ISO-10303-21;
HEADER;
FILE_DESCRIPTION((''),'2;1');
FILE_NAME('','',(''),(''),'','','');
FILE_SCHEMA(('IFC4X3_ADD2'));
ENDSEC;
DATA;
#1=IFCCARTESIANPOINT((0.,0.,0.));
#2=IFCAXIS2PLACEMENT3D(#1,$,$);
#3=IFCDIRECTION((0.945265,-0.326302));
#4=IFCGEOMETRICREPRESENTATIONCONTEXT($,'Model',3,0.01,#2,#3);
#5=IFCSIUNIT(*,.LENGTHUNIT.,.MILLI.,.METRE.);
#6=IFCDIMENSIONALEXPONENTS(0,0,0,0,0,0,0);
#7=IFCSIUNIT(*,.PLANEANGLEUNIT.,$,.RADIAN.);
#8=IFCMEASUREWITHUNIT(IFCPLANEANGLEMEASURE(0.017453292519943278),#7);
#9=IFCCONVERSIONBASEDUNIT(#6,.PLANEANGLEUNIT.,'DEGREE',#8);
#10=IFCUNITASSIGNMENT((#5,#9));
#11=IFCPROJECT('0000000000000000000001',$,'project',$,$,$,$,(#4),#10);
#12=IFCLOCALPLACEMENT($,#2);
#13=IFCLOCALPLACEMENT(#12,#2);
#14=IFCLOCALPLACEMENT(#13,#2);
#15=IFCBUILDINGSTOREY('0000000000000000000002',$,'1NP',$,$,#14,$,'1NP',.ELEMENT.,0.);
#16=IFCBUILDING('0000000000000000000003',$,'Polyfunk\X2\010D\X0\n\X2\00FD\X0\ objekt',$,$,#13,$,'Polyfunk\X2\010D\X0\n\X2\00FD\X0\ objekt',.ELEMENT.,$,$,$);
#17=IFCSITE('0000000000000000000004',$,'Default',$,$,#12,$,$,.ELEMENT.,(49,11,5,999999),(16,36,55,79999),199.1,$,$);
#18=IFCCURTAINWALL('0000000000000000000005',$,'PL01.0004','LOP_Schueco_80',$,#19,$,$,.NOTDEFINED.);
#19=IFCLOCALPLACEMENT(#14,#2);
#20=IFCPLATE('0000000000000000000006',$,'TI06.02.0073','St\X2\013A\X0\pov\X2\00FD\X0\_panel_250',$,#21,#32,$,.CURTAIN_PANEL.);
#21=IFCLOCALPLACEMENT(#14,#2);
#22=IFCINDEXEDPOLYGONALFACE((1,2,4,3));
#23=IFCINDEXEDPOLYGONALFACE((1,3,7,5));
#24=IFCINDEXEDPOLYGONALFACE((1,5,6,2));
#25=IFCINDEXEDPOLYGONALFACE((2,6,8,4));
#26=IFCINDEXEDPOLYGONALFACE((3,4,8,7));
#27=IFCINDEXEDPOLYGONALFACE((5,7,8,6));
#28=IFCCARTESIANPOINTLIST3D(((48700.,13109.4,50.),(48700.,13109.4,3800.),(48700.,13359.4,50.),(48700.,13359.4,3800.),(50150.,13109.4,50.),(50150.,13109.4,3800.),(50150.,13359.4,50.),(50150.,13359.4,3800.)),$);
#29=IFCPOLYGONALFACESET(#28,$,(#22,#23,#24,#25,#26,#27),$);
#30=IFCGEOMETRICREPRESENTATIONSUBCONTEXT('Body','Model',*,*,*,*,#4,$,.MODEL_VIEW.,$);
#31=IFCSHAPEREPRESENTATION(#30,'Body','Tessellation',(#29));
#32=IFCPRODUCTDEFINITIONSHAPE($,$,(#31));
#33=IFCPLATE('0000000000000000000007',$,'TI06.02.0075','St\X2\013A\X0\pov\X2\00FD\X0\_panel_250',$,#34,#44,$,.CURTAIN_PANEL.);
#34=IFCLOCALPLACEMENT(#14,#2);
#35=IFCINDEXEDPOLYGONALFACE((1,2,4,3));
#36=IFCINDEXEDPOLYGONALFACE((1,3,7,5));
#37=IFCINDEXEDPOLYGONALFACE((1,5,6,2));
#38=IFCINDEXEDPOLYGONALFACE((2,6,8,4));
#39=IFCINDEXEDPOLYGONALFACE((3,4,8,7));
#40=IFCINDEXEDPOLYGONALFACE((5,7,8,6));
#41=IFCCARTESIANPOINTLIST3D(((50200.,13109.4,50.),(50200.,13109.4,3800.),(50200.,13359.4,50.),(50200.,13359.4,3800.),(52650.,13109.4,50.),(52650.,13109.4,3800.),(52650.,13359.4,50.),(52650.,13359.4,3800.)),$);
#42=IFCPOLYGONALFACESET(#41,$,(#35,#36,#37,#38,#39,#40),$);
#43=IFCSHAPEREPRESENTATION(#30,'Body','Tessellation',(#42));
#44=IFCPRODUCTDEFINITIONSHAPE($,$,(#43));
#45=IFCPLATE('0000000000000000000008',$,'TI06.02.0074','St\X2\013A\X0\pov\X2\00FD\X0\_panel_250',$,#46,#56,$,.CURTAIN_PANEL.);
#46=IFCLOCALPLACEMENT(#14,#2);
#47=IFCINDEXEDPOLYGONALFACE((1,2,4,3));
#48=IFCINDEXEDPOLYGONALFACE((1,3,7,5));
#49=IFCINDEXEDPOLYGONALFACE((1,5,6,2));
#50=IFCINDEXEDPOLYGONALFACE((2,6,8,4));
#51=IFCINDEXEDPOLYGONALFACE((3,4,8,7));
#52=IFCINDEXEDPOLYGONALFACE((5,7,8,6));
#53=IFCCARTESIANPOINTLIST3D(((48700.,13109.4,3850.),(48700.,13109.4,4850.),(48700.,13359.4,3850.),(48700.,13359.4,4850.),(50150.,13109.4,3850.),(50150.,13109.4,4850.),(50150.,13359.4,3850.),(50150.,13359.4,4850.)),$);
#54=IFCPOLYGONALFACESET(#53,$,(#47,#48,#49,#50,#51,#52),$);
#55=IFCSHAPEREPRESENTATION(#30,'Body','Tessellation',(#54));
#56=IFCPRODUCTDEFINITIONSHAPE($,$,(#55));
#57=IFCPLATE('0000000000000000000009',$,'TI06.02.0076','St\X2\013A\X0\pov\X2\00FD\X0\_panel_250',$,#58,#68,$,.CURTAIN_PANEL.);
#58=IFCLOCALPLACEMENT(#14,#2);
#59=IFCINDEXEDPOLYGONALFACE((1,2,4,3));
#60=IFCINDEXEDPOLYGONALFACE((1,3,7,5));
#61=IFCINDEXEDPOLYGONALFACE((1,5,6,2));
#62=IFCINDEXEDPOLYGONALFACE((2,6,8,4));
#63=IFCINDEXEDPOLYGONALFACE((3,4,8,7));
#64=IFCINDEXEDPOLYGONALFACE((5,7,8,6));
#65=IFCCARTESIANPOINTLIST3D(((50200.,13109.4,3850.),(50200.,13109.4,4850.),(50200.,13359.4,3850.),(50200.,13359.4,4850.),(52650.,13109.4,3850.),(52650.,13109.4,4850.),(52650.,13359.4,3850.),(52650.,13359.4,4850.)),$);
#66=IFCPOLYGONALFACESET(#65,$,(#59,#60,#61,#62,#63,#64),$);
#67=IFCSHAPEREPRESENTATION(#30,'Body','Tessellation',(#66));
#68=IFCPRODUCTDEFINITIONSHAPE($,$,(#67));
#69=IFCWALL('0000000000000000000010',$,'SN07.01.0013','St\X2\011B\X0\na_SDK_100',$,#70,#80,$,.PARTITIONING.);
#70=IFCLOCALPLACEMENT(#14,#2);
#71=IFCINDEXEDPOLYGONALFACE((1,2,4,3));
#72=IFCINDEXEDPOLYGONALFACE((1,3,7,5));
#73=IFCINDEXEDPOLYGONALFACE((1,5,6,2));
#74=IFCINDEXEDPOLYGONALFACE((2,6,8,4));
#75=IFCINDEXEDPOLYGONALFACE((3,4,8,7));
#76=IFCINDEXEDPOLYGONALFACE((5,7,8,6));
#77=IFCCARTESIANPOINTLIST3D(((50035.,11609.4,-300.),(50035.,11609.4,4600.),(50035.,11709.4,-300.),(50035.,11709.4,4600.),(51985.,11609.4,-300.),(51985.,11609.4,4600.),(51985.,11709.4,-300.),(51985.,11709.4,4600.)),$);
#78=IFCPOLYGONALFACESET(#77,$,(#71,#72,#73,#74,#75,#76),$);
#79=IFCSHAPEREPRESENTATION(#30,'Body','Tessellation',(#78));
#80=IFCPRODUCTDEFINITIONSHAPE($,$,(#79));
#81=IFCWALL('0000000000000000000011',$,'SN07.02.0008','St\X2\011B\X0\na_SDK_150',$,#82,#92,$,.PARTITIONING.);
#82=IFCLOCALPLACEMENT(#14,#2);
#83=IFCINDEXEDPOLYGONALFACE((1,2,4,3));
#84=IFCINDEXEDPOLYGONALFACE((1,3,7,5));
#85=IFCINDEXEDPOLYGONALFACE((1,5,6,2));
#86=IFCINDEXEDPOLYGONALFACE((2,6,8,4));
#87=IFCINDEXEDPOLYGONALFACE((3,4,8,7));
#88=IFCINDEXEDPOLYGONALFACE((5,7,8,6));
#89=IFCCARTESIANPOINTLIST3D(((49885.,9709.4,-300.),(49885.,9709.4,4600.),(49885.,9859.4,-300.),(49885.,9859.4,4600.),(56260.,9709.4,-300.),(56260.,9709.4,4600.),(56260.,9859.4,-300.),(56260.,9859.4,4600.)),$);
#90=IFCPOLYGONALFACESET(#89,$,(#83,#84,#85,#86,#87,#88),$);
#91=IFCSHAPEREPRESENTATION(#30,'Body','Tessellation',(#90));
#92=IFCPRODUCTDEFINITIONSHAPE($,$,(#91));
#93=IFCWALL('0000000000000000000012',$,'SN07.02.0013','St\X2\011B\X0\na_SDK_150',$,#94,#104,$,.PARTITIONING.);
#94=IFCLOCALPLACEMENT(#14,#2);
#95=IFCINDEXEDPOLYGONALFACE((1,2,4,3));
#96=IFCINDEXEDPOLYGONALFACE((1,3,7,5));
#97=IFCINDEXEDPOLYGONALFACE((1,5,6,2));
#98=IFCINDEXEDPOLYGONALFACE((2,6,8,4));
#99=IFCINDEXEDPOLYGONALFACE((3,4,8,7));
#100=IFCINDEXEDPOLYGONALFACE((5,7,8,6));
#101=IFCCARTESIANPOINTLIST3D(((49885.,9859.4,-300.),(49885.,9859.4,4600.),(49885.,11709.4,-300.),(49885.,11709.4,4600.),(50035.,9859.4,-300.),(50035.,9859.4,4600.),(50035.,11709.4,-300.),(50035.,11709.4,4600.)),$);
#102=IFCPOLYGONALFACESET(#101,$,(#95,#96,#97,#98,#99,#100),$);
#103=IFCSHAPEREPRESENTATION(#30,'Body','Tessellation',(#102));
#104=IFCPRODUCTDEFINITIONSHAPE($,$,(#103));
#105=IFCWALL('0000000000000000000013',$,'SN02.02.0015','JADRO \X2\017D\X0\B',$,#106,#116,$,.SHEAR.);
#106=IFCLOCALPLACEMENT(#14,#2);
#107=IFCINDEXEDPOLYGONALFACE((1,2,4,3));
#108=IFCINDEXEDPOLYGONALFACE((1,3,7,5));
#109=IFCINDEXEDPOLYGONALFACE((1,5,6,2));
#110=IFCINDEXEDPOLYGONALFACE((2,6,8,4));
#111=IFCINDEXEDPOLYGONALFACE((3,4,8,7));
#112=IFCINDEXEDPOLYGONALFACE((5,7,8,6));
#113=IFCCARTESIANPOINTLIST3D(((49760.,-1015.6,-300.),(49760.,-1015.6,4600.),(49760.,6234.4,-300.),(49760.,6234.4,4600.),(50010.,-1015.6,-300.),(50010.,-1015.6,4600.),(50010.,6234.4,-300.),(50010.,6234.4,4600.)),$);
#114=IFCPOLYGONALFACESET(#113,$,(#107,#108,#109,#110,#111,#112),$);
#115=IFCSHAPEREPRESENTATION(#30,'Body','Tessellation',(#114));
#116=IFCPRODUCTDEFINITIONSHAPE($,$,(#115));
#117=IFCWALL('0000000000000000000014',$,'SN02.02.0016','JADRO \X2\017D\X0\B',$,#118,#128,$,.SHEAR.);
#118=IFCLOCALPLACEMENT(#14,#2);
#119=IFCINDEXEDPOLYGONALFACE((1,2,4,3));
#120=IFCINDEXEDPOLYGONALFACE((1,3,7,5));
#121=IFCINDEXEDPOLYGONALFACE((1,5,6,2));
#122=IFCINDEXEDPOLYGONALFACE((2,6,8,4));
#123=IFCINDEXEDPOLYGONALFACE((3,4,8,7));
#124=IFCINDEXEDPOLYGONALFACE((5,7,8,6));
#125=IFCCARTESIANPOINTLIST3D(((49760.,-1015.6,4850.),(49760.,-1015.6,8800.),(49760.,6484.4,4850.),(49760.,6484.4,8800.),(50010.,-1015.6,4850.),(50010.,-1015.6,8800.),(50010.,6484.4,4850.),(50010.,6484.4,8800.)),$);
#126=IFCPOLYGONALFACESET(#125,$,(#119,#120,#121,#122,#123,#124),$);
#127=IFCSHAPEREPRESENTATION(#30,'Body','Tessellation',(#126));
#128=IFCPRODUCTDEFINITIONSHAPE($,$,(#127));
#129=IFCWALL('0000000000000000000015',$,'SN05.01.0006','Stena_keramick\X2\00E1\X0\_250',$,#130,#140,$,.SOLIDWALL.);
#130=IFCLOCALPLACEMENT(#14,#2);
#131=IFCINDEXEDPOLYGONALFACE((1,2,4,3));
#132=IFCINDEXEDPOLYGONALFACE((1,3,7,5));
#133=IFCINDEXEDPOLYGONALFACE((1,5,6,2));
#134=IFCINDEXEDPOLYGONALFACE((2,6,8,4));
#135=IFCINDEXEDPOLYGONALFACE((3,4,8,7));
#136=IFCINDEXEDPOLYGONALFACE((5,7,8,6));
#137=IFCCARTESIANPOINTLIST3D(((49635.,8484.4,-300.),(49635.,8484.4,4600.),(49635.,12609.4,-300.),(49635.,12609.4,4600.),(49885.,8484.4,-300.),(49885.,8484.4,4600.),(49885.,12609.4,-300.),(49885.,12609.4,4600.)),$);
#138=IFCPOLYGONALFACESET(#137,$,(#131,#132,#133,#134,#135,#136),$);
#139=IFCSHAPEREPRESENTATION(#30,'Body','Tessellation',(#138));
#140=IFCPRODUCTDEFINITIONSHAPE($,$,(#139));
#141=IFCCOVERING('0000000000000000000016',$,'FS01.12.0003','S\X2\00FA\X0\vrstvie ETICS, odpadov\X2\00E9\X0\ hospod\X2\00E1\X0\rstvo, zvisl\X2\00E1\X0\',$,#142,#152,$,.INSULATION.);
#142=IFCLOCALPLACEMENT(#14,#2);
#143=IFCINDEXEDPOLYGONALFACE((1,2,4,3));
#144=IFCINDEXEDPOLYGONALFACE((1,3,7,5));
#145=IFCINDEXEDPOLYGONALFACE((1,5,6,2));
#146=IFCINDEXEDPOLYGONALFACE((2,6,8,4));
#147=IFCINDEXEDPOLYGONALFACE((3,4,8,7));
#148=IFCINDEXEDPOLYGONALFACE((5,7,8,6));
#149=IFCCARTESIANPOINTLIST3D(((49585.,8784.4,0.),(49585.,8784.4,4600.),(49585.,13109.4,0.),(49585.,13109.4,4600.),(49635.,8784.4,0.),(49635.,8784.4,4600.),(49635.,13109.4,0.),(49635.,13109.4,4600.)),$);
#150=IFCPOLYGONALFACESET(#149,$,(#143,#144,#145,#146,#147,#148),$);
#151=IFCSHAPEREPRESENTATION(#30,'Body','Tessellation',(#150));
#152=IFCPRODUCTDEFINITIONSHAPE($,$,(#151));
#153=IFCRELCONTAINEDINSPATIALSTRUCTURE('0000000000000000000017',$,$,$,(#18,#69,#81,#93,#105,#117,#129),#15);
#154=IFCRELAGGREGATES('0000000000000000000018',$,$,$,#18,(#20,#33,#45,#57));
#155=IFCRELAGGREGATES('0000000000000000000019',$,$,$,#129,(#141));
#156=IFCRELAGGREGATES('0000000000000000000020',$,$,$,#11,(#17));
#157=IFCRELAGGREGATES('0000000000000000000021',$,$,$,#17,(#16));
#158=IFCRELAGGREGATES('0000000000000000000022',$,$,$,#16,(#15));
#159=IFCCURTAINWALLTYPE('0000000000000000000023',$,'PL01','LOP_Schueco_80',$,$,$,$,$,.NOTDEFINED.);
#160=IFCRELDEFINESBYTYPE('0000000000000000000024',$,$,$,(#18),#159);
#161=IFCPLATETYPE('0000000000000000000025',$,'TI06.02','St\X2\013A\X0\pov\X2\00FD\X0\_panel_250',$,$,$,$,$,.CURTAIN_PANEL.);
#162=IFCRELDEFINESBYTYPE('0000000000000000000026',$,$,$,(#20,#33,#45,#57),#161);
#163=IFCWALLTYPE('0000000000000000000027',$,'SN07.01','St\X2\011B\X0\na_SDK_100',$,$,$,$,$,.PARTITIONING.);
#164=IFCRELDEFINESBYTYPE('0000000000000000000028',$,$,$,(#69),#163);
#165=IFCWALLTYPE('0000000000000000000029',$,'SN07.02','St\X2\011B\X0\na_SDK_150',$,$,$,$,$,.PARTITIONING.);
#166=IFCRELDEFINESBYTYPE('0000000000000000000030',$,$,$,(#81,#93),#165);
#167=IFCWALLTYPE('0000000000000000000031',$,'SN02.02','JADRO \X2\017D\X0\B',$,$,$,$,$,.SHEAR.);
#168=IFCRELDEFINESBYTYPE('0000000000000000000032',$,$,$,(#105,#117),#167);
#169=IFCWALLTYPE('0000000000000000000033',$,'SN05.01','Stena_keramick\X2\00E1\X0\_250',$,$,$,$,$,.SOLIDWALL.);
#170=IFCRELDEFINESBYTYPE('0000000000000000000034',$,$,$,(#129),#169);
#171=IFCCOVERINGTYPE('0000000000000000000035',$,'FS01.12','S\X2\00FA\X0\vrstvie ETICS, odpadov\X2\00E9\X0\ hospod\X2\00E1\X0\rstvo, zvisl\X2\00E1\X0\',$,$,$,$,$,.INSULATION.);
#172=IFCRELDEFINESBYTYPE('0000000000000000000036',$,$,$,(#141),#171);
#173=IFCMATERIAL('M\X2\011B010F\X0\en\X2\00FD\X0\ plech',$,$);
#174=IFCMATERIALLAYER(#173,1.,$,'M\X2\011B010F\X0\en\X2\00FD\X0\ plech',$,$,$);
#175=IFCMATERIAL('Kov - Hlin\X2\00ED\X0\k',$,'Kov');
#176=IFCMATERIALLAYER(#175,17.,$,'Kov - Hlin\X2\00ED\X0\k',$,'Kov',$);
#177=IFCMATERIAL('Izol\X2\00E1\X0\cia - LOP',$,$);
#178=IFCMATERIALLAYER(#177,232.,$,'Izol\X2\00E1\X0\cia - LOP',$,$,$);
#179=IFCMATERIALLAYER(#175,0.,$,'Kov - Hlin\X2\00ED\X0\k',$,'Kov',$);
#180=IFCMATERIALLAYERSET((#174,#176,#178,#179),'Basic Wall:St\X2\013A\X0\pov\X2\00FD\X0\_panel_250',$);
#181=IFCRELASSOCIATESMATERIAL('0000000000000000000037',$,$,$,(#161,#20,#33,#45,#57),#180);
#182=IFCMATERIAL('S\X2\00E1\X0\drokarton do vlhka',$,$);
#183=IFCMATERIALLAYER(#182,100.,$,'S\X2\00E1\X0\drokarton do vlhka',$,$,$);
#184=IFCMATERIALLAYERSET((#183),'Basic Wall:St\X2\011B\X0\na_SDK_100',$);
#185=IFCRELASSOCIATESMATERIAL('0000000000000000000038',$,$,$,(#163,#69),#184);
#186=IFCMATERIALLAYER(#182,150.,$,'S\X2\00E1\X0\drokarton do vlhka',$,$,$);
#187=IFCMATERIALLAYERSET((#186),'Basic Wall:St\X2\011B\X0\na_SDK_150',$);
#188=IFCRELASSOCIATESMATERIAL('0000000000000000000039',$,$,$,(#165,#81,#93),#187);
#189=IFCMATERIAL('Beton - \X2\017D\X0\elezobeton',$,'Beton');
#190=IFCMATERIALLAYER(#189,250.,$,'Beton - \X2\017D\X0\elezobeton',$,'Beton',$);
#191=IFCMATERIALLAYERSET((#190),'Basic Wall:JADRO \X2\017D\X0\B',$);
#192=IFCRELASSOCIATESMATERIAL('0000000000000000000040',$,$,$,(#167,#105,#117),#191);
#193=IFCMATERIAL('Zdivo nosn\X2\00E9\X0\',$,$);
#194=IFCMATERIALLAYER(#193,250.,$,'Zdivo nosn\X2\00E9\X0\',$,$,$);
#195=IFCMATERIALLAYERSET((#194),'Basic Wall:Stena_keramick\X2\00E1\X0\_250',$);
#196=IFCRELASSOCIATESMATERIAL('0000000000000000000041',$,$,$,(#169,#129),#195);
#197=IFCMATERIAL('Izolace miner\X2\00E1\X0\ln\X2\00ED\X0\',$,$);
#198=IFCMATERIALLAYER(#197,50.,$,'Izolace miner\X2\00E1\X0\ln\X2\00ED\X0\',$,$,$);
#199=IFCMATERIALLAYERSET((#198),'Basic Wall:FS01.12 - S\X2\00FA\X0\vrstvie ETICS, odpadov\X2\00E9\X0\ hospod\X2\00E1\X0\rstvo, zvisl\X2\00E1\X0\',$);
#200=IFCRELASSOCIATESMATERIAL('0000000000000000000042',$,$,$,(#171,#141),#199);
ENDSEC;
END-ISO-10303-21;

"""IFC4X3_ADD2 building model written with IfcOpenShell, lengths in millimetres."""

from ifc_helpers import new_model, entity, si_unit, converted_unit, direction, frame, frame_2d, origin, origin_2d_with_axis, place, context, subcontext, project, spatial, polyline, rectangle, extrude, clip, bounded_halfspace, material, layer, layer_set, layer_usage, type_object, element, aggregate, save


model = new_model("IFC4X3_ADD2")

# Units and contexts
model_context = context("Model", 3, precision=0.01, world=origin(), true_north=direction((0.945265, -0.326302)))
body_context = subcontext(model_context, "Body", "Model", "MODEL_VIEW")
ifc_project = project(units=[si_unit("LENGTHUNIT", "METRE", prefix="MILLI"), converted_unit("PLANEANGLEUNIT", "DEGREE", entity("IfcPlaneAngleMeasure", 0.017453292519943278), si_unit("PLANEANGLEUNIT", "RADIAN"), dimensions=[0, 0, 0, 0, 0, 0, 0])], contexts=[model_context])

# Site, building, storey
site_placement = place(None, origin())
site = spatial("IfcSite", under=ifc_project, at=site_placement, Name="Default", CompositionType="ELEMENT", RefLatitude=(49, 11, 5, 999999), RefLongitude=(16, 36, 55, 79999), RefElevation=199.1)
building_placement = place(site_placement, origin())
building = spatial("IfcBuilding", under=site, at=building_placement, Name="Polyfunkčný objekt", LongName="Polyfunkčný objekt", CompositionType="ELEMENT")
storey_placement = place(building_placement, origin())
storey = spatial("IfcBuildingStorey", under=building, at=storey_placement, Name="1NP", LongName="1NP", CompositionType="ELEMENT", Elevation=0.0)

# Curtain wall, plates
curtain_wall_type = type_object("IfcCurtainWallType", Name="PL01", Description="LOP_Schueco_80", PredefinedType="NOTDEFINED")
curtain_wall_placement = place(storey_placement, origin())
curtain_wall = element("IfcCurtainWall", 1, at=curtain_wall_placement, inside=storey, type_object=curtain_wall_type, Name="PL01.0004", Description="LOP_Schueco_80", PredefinedType="NOTDEFINED")
ifc_material_1 = material(Name="Měďený plech")
ifc_layer_1 = layer(ifc_material_1, 1.0, Name="Měďený plech")
ifc_material_2 = material(Name="Kov - Hliník", Category="Kov")
ifc_layer_2 = layer(ifc_material_2, 17.0, Name="Kov - Hliník", Category="Kov")
ifc_material_3 = material(Name="Izolácia - LOP")
ifc_layer_3 = layer(ifc_material_3, 232.0, Name="Izolácia - LOP")
ifc_layer_4 = layer(ifc_material_2, 0.0, Name="Kov - Hliník", Category="Kov")
ifc_layer_set_1 = layer_set([ifc_layer_1, ifc_layer_2, ifc_layer_3, ifc_layer_4], Name="Basic Wall:Stĺpový_panel_250")
ifc_layer_usage_1 = layer_usage(ifc_layer_set_1, "AXIS2", "NEGATIVE", 125.0)
plate_type = type_object("IfcPlateType", Name="TI06.02", Description="Stĺpový_panel_250", PredefinedType="CURTAIN_PANEL", material=ifc_layer_set_1)
plate_1_placement = place(storey_placement, frame((48700.0, 13234.4, 50.0)))
plate_1 = element("IfcPlate", 2, at=plate_1_placement, type_object=plate_type, material=ifc_layer_usage_1, Name="TI06.02.0073", Description="Stĺpový_panel_250", PredefinedType="CURTAIN_PANEL", context=body_context, shape_type="SweptSolid", body=[
    extrude(rectangle(XDim=250.0, YDim=1450.0, at=frame_2d((0.0, 0.0), x_axis=(1.0, 0.0))), frame((725.0, 0.0, 0.0), z_axis=(0.0, 0.0, 1.0), x_axis=(0.0, 1.0, 0.0)), (0.0, 0.0, 1.0), 3750.0),
])
ifc_layer_usage_2 = layer_usage(ifc_layer_set_1, "AXIS2", "NEGATIVE", 125.0)
plate_2_placement = place(storey_placement, frame((50200.0, 13234.4, 50.0)))
plate_2 = element("IfcPlate", 3, at=plate_2_placement, type_object=plate_type, material=ifc_layer_usage_2, Name="TI06.02.0075", Description="Stĺpový_panel_250", PredefinedType="CURTAIN_PANEL", context=body_context, shape_type="SweptSolid", body=[
    extrude(rectangle(XDim=250.0, YDim=2450.0, at=origin_2d_with_axis()), frame((1225.0, 0.0, 0.0), z_axis=(0.0, 0.0, 1.0), x_axis=(0.0, 1.0, 0.0)), (0.0, 0.0, 1.0), 3750.0),
])
ifc_layer_usage_3 = layer_usage(ifc_layer_set_1, "AXIS2", "NEGATIVE", 125.0)
plate_3_placement = place(storey_placement, frame((48700.0, 13234.4, 3850.0)))
plate_3 = element("IfcPlate", 4, at=plate_3_placement, type_object=plate_type, material=ifc_layer_usage_3, Name="TI06.02.0074", Description="Stĺpový_panel_250", PredefinedType="CURTAIN_PANEL", context=body_context, shape_type="SweptSolid", body=[
    extrude(rectangle(XDim=250.0, YDim=1450.0, at=frame_2d((0.0, 0.0), x_axis=(1.0, 0.0))), frame((725.0, 0.0, 0.0), z_axis=(0.0, 0.0, 1.0), x_axis=(0.0, 1.0, 0.0)), (0.0, 0.0, 1.0), 1000.0),
])
ifc_layer_usage_4 = layer_usage(ifc_layer_set_1, "AXIS2", "NEGATIVE", 125.0)
plate_4_placement = place(storey_placement, frame((50200.0, 13234.4, 3850.0)))
plate_4 = element("IfcPlate", 5, at=plate_4_placement, type_object=plate_type, material=ifc_layer_usage_4, Name="TI06.02.0076", Description="Stĺpový_panel_250", PredefinedType="CURTAIN_PANEL", context=body_context, shape_type="SweptSolid", body=[
    extrude(rectangle(XDim=250.0, YDim=2450.0, at=origin_2d_with_axis()), frame((1225.0, 0.0, 0.0), z_axis=(0.0, 0.0, 1.0), x_axis=(0.0, 1.0, 0.0)), (0.0, 0.0, 1.0), 1000.0),
])
aggregate(curtain_wall, [plate_1, plate_2, plate_3, plate_4])

# Walls
ifc_material_4 = material(Name="Sádrokarton do vlhka")
ifc_layer_5 = layer(ifc_material_4, 100.0, Name="Sádrokarton do vlhka")
ifc_layer_set_2 = layer_set([ifc_layer_5], Name="Basic Wall:Stěna_SDK_100")
wall_type_1 = type_object("IfcWallType", Name="SN07.01", Description="Stěna_SDK_100", PredefinedType="PARTITIONING", material=ifc_layer_set_2)
wall_1_placement = place(storey_placement, frame((51985.0, 11659.4, -300.0), z_axis=(0.0, 0.0, 1.0), x_axis=(-1.0, 0.0, 0.0)))
element("IfcWall", 6, at=wall_1_placement, inside=storey, type_object=wall_type_1, material=ifc_layer_set_2, Name="SN07.01.0013", Description="Stěna_SDK_100", PredefinedType="PARTITIONING", context=body_context, shape_type="Clipping", body=[
    clip(clip(extrude(rectangle(XDim=1950.0, YDim=100.0, at=frame_2d((975.0, 0.0), x_axis=(-1.0, 0.0))), origin(), (0.0, 0.0, 1.0), 4900.0), bounded_halfspace(frame((0.0, -50.0, 4900.0), z_axis=(0.0, 0.0, -1.0), x_axis=(-1.0, 0.0, 0.0)), True, frame((0.0, -50.0, 4900.0)), polyline([(0.0, 0.0), (1950.0, 0.0), (1950.0, 100.0), (1050.0, 100.0), (900.0, 100.0), (0.0, 100.0), (0.0, 0.0)]))), bounded_halfspace(frame((1950.0, -50.0, 0.0), z_axis=(0.0, 0.0, 1.0), x_axis=(0.0, -1.0, 0.0)), True, frame((1950.0, -50.0, 0.0)), polyline([(0.0, 0.0), (0.0, 100.0), (-900.0, 100.0), (-1050.0, 100.0), (-1950.0, 100.0), (-1950.0, 0.0), (0.0, 0.0)]))),
])
ifc_layer_6 = layer(ifc_material_4, 150.0, Name="Sádrokarton do vlhka")
ifc_layer_set_3 = layer_set([ifc_layer_6], Name="Basic Wall:Stěna_SDK_150")
wall_type_2 = type_object("IfcWallType", Name="SN07.02", Description="Stěna_SDK_150", PredefinedType="PARTITIONING", material=ifc_layer_set_3)
wall_2_placement = place(storey_placement, frame((49885.0, 9784.4, -300.0)))
element("IfcWall", 7, at=wall_2_placement, inside=storey, type_object=wall_type_2, material=ifc_layer_set_3, Name="SN07.02.0008", Description="Stěna_SDK_150", PredefinedType="PARTITIONING", context=body_context, shape_type="Clipping", body=[
    clip(clip(extrude(rectangle(XDim=6375.0, YDim=150.0, at=frame_2d((3187.5, 0.0), x_axis=(-1.0, 0.0))), origin(), (0.0, 0.0, 1.0), 4900.0), bounded_halfspace(frame((0.0, -75.0, 4900.0), z_axis=(0.0, 0.0, -1.0), x_axis=(1.0, 0.0, 0.0)), True, frame((0.0, -75.0, 4900.0)), polyline([(0.0, 0.0), (6375.0, 0.0), (6375.0, 150.0), (2250.0, 150.0), (2100.0, 150.0), (1200.0, 150.0), (1050.0, 150.0), (150.0, 150.0), (0.0, 150.0), (0.0, 0.0)]))), bounded_halfspace(frame((6375.0, -75.0, 0.0), z_axis=(0.0, 0.0, 1.0), x_axis=(0.0, 1.0, 0.0)), True, frame((6375.0, -75.0, 0.0)), polyline([(0.0, 0.0), (0.0, 150.0), (-4125.0, 150.0), (-4275.0, 150.0), (-5175.0, 150.0), (-5325.0, 150.0), (-6225.0, 150.0), (-6375.0, 150.0), (-6375.0, 0.0), (0.0, 0.0)]))),
])
wall_3_placement = place(storey_placement, frame((49960.0, 9859.4, -300.0), z_axis=(0.0, 0.0, 1.0), x_axis=(0.0, 1.0, 0.0)))
element("IfcWall", 8, at=wall_3_placement, inside=storey, type_object=wall_type_2, material=ifc_layer_set_3, Name="SN07.02.0013", Description="Stěna_SDK_150", PredefinedType="PARTITIONING", context=body_context, shape_type="Clipping", body=[
    clip(clip(extrude(rectangle(XDim=1850.0, YDim=150.0, at=frame_2d((925.0, 0.0), x_axis=(-1.0, 0.0))), origin(), (0.0, 0.0, 1.0), 4900.0), bounded_halfspace(frame((0.0, -75.0, 4900.0), z_axis=(0.0, 0.0, -1.0), x_axis=(0.0, -1.0, 0.0)), True, frame((0.0, -75.0, 4900.0)), polyline([(0.0, 0.0), (1750.0, 0.0), (1850.0, 0.0), (1850.0, 150.0), (0.0, 150.0), (0.0, 0.0)]))), bounded_halfspace(frame((1850.0, -75.0, 0.0)), True, frame((1850.0, -75.0, 0.0)), polyline([(0.0, 0.0), (0.0, 150.0), (-1850.0, 150.0), (-1850.0, 0.0), (-100.0, 0.0), (0.0, 0.0)]))),
])
ifc_material_5 = material(Name="Beton - Železobeton", Category="Beton")
ifc_layer_7 = layer(ifc_material_5, 250.0, Name="Beton - Železobeton", Category="Beton")
ifc_layer_set_4 = layer_set([ifc_layer_7], Name="Basic Wall:JADRO ŽB")
wall_type_3 = type_object("IfcWallType", Name="SN02.02", Description="JADRO ŽB", PredefinedType="SHEAR", material=ifc_layer_set_4)
wall_4_placement = place(storey_placement, frame((49885.0, 6234.4, -300.0), z_axis=(0.0, 0.0, 1.0), x_axis=(0.0, -1.0, 0.0)))
element("IfcWall", 9, at=wall_4_placement, inside=storey, type_object=wall_type_3, material=ifc_layer_set_4, Name="SN02.02.0015", Description="JADRO ŽB", PredefinedType="SHEAR", context=body_context, shape_type="Clipping", body=[
    clip(clip(extrude(rectangle(XDim=7250.0, YDim=250.0, at=frame_2d((3625.0, 0.0), x_axis=(-1.0, 0.0))), origin(), (0.0, 0.0, 1.0), 4900.0), bounded_halfspace(frame((0.0, -125.0, 4900.0), z_axis=(0.0, 0.0, -1.0), x_axis=(0.0, 1.0, 0.0)), True, frame((0.0, -125.0, 4900.0)), polyline([(0.0, 0.0), (800.0, 0.0), (950.0, 0.0), (7250.0, 0.0), (7250.0, 250.0), (0.0, 250.0), (0.0, 0.0)]))), bounded_halfspace(frame((7250.0, -125.0, 0.0), z_axis=(0.0, 0.0, 1.0), x_axis=(-1.0, 0.0, 0.0)), True, frame((7250.0, -125.0, 0.0)), polyline([(0.0, 0.0), (0.0, 250.0), (-7250.0, 250.0), (-7250.0, 0.0), (-6450.0, 0.0), (-6300.0, 0.0), (0.0, 0.0)]))),
])
wall_5_placement = place(storey_placement, frame((49885.0, 6484.4, 4850.0), z_axis=(0.0, 0.0, 1.0), x_axis=(0.0, -1.0, 0.0)))
element("IfcWall", 10, at=wall_5_placement, inside=storey, type_object=wall_type_3, material=ifc_layer_set_4, Name="SN02.02.0016", Description="JADRO ŽB", PredefinedType="SHEAR", context=body_context, shape_type="Clipping", body=[
    clip(clip(extrude(rectangle(XDim=7500.0, YDim=250.0, at=frame_2d((3750.0, 0.0), x_axis=(-1.0, 0.0))), origin(), (0.0, 0.0, 1.0), 3950.0), bounded_halfspace(frame((7500.0, -125.0, 0.0), z_axis=(0.0, 0.0, 1.0), x_axis=(0.0, -1.0, 0.0)), True, frame((7500.0, -125.0, 0.0)), polyline([(0.0, 0.0), (0.0, 250.0), (-7500.0, 250.0), (-7500.0, 0.0), (-7250.0, 0.0), (-6450.0, 0.0), (-6300.0, 0.0), (0.0, 0.0)]))), bounded_halfspace(frame((0.0, -125.0, 3950.0), z_axis=(0.0, 0.0, -1.0), x_axis=(0.0, 1.0, 0.0)), True, frame((0.0, -125.0, 3950.0)), polyline([(0.0, 0.0), (250.0, 0.0), (1050.0, 0.0), (1200.0, 0.0), (7500.0, 0.0), (7500.0, 250.0), (0.0, 250.0), (0.0, 0.0)]))),
])

# Wall
ifc_material_6 = material(Name="Zdivo nosné")
ifc_layer_8 = layer(ifc_material_6, 250.0, Name="Zdivo nosné")
ifc_layer_set_5 = layer_set([ifc_layer_8], Name="Basic Wall:Stena_keramická_250")
wall_type_4 = type_object("IfcWallType", Name="SN05.01", Description="Stena_keramická_250", PredefinedType="SOLIDWALL", material=ifc_layer_set_5)
wall_6_placement = place(storey_placement, frame((49760.0, 12609.4, -300.0), z_axis=(0.0, 0.0, 1.0), x_axis=(0.0, -1.0, 0.0)))
wall_6 = element("IfcWall", 11, at=wall_6_placement, inside=storey, type_object=wall_type_4, material=ifc_layer_set_5, Name="SN05.01.0006", Description="Stena_keramická_250", PredefinedType="SOLIDWALL", context=body_context, shape_type="Clipping", body=[
    clip(clip(extrude(rectangle(XDim=4125.0, YDim=250.0, at=frame_2d((2062.5, 0.0), x_axis=(-1.0, 0.0))), origin(), (0.0, 0.0, 1.0), 4900.0), bounded_halfspace(frame((0.0, -125.0, 4900.0), z_axis=(0.0, 0.0, -1.0), x_axis=(0.0, 1.0, 0.0)), True, frame((0.0, -125.0, 4900.0)), polyline([(0.0, 0.0), (3875.0, 0.0), (4125.0, 0.0), (4125.0, 250.0), (0.0, 250.0), (0.0, 0.0)]))), bounded_halfspace(frame((4125.0, -125.0, 0.0), z_axis=(0.0, 0.0, 1.0), x_axis=(-1.0, 0.0, 0.0)), True, frame((4125.0, -125.0, 0.0)), polyline([(0.0, 0.0), (0.0, 250.0), (-4125.0, 250.0), (-4125.0, 0.0), (-250.0, 0.0), (0.0, 0.0)]))),
])

# Covering
ifc_material_7 = material(Name="Izolace minerální")
ifc_layer_9 = layer(ifc_material_7, 50.0, Name="Izolace minerální")
ifc_layer_set_6 = layer_set([ifc_layer_9], Name="Basic Wall:FS01.12 - Súvrstvie ETICS, odpadové hospodárstvo, zvislá")
covering_type_1 = type_object("IfcCoveringType", Name="FS01.12", Description="Súvrstvie ETICS, odpadové hospodárstvo, zvislá", PredefinedType="INSULATION", material=ifc_layer_set_6)
covering_1_placement = place(storey_placement, frame((49610.0, 8784.4, 0.0), z_axis=(0.0, 0.0, 1.0), x_axis=(0.0, 1.0, 0.0)))
covering_1 = element("IfcCovering", 12, at=covering_1_placement, type_object=covering_type_1, material=ifc_layer_set_6, Name="FS01.12.0003", Description="Súvrstvie ETICS, odpadové hospodárstvo, zvislá", PredefinedType="INSULATION", context=body_context, shape_type="SweptSolid", body=[
    extrude(rectangle(XDim=4325.0, YDim=50.0, at=frame_2d((2162.5, 0.0), x_axis=(-1.0, 0.0))), origin(), (0.0, 0.0, 1.0), 4600.0),
])
aggregate(wall_6, [covering_1])

save(model, "model.ifc")
